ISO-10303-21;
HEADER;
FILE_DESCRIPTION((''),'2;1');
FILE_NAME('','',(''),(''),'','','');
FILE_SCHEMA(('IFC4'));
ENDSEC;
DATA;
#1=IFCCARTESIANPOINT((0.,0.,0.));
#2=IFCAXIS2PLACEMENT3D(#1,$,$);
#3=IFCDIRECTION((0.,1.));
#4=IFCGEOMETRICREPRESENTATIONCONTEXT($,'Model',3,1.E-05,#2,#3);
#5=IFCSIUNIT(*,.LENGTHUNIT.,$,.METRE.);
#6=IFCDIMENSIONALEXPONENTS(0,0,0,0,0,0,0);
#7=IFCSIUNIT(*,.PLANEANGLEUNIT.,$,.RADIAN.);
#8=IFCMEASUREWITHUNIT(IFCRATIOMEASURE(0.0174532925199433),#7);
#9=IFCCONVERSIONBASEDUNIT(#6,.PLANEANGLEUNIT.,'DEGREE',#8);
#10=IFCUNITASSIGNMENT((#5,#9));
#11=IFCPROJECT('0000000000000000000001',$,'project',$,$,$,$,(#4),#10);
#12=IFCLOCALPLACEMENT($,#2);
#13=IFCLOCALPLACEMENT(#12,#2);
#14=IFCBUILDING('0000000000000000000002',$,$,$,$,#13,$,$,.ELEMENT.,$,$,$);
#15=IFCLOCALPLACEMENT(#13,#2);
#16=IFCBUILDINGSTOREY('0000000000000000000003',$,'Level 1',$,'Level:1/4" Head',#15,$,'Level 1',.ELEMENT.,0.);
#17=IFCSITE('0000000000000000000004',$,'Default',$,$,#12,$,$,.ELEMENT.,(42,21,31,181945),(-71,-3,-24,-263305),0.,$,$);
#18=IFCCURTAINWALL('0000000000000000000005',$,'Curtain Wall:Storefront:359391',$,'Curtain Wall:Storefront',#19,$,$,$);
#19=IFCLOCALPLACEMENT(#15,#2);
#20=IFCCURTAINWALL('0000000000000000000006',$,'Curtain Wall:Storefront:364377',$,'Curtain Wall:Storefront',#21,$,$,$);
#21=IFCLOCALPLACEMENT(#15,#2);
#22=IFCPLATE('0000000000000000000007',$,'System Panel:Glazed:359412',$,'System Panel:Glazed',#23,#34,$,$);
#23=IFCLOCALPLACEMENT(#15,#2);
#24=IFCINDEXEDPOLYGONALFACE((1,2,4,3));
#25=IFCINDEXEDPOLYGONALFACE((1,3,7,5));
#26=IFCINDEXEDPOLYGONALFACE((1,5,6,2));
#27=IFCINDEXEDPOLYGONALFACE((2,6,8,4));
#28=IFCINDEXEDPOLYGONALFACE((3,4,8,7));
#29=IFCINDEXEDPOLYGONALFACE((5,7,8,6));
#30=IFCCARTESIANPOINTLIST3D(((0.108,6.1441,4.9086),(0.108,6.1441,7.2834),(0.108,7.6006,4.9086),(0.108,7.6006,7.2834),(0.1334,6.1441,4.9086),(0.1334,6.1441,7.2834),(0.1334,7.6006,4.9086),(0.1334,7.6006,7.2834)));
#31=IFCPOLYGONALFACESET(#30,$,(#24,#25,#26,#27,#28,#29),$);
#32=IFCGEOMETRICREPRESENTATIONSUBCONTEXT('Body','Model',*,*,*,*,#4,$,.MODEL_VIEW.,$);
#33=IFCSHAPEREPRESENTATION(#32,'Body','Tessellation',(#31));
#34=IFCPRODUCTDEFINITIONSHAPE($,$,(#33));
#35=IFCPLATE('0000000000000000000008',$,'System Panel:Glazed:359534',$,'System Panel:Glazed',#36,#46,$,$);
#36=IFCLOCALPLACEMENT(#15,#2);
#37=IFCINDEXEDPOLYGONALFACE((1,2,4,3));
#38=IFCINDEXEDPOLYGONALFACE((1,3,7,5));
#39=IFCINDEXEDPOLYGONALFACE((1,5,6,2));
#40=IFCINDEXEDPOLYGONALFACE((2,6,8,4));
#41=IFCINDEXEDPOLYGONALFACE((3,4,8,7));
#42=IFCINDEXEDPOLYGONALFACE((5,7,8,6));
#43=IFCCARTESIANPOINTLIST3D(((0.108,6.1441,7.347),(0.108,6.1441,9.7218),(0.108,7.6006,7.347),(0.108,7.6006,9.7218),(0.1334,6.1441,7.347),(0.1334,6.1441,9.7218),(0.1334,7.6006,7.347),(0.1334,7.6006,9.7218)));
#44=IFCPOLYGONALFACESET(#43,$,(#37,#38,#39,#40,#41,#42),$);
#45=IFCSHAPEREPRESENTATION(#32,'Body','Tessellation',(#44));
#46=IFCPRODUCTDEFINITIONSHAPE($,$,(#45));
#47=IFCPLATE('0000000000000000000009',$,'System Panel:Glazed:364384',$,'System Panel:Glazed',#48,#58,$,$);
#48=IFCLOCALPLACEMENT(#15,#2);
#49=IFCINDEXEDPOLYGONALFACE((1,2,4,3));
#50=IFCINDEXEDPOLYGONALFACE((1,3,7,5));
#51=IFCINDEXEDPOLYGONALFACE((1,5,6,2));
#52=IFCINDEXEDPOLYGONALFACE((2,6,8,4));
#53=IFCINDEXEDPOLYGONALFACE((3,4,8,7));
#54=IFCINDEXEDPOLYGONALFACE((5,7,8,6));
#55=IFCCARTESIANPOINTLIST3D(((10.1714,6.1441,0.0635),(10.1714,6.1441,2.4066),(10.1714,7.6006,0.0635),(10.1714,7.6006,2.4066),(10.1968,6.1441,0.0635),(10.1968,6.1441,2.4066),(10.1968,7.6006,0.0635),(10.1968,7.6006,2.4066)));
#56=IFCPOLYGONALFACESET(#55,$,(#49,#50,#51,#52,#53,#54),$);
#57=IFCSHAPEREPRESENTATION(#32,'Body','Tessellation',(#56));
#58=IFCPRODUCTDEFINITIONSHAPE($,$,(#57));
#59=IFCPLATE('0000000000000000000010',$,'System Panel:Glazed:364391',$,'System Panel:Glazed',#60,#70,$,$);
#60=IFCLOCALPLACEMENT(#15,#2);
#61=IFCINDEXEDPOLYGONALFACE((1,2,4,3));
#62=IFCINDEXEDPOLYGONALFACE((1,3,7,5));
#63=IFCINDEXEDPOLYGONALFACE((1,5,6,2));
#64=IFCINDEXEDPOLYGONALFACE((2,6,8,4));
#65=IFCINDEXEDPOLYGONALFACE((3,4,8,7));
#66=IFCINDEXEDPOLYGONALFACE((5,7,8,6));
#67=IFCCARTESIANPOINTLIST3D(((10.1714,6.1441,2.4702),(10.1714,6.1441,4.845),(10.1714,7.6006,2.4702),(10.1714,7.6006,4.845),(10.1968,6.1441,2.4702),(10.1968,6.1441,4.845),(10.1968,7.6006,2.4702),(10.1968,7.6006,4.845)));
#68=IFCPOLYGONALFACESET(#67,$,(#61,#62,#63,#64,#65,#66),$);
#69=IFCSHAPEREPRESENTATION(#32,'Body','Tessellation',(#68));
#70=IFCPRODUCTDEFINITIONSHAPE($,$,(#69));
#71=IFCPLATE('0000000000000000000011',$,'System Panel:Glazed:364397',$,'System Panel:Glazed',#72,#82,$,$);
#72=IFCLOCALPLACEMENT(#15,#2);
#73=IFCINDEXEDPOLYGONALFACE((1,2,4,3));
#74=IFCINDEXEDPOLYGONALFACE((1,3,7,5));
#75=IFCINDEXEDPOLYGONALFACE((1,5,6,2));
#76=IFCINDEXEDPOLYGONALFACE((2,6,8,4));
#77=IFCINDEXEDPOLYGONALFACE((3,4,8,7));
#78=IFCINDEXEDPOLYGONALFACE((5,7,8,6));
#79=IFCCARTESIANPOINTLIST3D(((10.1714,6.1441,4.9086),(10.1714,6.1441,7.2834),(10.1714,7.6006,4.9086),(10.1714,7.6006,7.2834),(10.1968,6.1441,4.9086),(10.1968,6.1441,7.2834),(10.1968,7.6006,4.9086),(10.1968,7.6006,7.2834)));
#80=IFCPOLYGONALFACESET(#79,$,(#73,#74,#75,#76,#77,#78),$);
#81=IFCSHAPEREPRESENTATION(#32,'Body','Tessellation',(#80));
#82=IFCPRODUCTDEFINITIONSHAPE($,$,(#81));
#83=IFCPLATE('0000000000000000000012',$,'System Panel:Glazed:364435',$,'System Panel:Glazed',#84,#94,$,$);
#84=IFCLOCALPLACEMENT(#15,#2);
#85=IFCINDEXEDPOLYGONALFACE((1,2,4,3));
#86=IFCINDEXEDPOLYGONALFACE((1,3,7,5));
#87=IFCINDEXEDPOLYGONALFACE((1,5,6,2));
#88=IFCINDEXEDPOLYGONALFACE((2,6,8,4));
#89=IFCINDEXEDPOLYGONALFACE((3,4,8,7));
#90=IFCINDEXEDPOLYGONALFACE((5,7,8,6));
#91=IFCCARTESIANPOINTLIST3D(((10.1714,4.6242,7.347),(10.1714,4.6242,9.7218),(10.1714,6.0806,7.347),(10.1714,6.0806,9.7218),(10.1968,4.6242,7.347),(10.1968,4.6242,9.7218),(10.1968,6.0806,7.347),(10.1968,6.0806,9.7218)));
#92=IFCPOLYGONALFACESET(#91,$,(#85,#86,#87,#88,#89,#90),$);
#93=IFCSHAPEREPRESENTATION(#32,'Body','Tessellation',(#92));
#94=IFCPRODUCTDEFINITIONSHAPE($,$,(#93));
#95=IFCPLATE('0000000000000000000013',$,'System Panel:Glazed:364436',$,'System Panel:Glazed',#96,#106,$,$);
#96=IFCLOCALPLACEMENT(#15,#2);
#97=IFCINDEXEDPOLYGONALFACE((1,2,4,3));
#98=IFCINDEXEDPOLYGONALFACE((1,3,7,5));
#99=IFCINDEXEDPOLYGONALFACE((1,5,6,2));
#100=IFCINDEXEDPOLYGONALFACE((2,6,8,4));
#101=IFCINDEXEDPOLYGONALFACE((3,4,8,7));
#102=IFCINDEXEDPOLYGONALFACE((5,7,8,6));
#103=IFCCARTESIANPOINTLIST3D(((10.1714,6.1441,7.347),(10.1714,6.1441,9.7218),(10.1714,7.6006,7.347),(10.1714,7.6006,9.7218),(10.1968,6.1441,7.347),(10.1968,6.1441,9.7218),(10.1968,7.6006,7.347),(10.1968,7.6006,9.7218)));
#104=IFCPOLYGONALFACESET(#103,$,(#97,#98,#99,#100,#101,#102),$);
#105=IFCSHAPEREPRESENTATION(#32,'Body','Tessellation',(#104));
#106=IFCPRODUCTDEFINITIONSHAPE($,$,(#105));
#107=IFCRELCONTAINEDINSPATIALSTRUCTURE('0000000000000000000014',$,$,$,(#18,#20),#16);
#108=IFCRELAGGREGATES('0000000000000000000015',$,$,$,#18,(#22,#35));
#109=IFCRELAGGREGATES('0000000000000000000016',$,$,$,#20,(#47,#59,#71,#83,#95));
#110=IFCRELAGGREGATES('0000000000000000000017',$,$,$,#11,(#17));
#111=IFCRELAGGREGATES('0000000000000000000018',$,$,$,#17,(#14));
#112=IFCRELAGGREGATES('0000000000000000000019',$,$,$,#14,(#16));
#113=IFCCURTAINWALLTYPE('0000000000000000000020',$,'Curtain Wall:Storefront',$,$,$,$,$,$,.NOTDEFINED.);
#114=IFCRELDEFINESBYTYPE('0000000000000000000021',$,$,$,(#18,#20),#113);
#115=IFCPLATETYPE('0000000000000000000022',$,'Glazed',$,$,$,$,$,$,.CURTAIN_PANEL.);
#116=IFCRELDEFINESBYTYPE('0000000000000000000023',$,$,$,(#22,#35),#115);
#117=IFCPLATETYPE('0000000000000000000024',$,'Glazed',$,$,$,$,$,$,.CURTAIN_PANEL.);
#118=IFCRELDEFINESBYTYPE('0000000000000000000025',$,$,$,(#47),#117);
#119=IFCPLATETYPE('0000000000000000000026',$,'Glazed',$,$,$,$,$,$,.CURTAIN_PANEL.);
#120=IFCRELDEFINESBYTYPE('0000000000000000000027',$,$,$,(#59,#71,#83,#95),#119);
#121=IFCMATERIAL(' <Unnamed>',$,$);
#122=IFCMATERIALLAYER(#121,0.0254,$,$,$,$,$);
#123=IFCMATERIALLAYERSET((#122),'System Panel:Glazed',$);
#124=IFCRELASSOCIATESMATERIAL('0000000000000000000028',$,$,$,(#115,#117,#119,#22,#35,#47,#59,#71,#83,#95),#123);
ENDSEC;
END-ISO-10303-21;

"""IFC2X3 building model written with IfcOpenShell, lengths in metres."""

from ifc_helpers import new_model, entity, si_unit, converted_unit, direction, frame, frame_2d, origin, origin_2d_with_axis, place, context, subcontext, project, spatial, rectangle, extrude, source, transform, mapped, material, layer, layer_set, layer_usage, type_object, type_shapes, element, aggregate, save


model = new_model("IFC2X3")

# Units and contexts
model_context = context("Model", 3, precision=1e-05, world=origin(), true_north=direction((0.0, 1.0)))
body_context = subcontext(model_context, "Body", "Model", "MODEL_VIEW")
ifc_project = project(units=[si_unit("LENGTHUNIT", "METRE"), converted_unit("PLANEANGLEUNIT", "DEGREE", entity("IfcRatioMeasure", 0.0174532925199433), si_unit("PLANEANGLEUNIT", "RADIAN"), dimensions=[0, 0, 0, 0, 0, 0, 0])], contexts=[model_context])

# Site, building, storey
site_placement = place(None, origin())
site = spatial("IfcSite", under=ifc_project, at=site_placement, Name="Default", CompositionType="ELEMENT", RefLatitude=(42, 21, 31, 181945), RefLongitude=(-71, -3, -24, -263305), RefElevation=0.0)
building_placement = place(site_placement, origin())
building = spatial("IfcBuilding", under=site, at=building_placement, CompositionType="ELEMENT")
storey_placement = place(building_placement, origin())
storey = spatial("IfcBuildingStorey", under=building, at=storey_placement, Name="Level 1", ObjectType="Level:1/4\" Head", LongName="Level 1", CompositionType="ELEMENT", Elevation=0.0)

# Curtain walls
curtain_wall_type = type_object("IfcCurtainWallType", Name="Curtain Wall:Storefront", PredefinedType="NOTDEFINED")
curtain_wall_1_placement = place(storey_placement, origin())
curtain_wall_1 = element("IfcCurtainWall", 1, at=curtain_wall_1_placement, inside=storey, type_object=curtain_wall_type, Name="Curtain Wall:Storefront:359391", ObjectType="Curtain Wall:Storefront")
curtain_wall_2_placement = place(storey_placement, origin())
curtain_wall_2 = element("IfcCurtainWall", 2, at=curtain_wall_2_placement, inside=storey, type_object=curtain_wall_type, Name="Curtain Wall:Storefront:364377", ObjectType="Curtain Wall:Storefront")

# Plates
ifc_material_1 = material(Name=" <Unnamed>")
ifc_layer = layer(ifc_material_1, 0.0254)
ifc_layer_set = layer_set([ifc_layer], Name="System Panel:Glazed")
plate_type_1 = type_object("IfcPlateType", Name="Glazed", PredefinedType="CURTAIN_PANEL", material=ifc_layer_set)
shared_shape_1 = source(origin(), body_context, "Body", "SweptSolid", [
    extrude(rectangle(XDim=0.0254, YDim=1.4565, at=frame_2d((0.0, 0.0), x_axis=(1.0, 0.0))), frame((0.7282, 0.0127, 0.0), z_axis=(0.0, 0.0, 1.0), x_axis=(0.0, 1.0, 0.0)), (0.0, 0.0, 1.0), 2.3749),
])
type_shapes(plate_type_1, [shared_shape_1])
ifc_layer_usage_1 = layer_usage(ifc_layer_set, "AXIS3", "POSITIVE", 0.1042)
plate_1_placement = place(curtain_wall_1_placement, frame((0.1334, 6.1441, 4.9085), z_axis=(0.0, 0.0, 1.0), x_axis=(0.0, 1.0, 0.0)))
plate_1 = element("IfcPlate", 3, at=plate_1_placement, type_object=plate_type_1, material=ifc_layer_usage_1, Name="System Panel:Glazed:359412", ObjectType="System Panel:Glazed", context=body_context, shape_type="MappedRepresentation", body=[
    mapped(shared_shape_1, transform((0.0, 0.0, 0.0), scale=1.0)),
])
ifc_layer_usage_2 = layer_usage(ifc_layer_set, "AXIS3", "POSITIVE", 0.1042)
plate_2_placement = place(curtain_wall_1_placement, frame((0.1334, 6.1441, 7.3469), z_axis=(0.0, 0.0, 1.0), x_axis=(0.0, 1.0, 0.0)))
plate_2 = element("IfcPlate", 4, at=plate_2_placement, type_object=plate_type_1, material=ifc_layer_usage_2, Name="System Panel:Glazed:359534", ObjectType="System Panel:Glazed", context=body_context, shape_type="MappedRepresentation", body=[
    mapped(shared_shape_1, transform((0.0, 0.0, 0.0), scale=1.0)),
])
aggregate(curtain_wall_1, [plate_1, plate_2])
ifc_layer_usage_3 = layer_usage(ifc_layer_set, "AXIS3", "POSITIVE", 0.1042)
plate_type_2 = type_object("IfcPlateType", Name="Glazed", PredefinedType="CURTAIN_PANEL", material=ifc_layer_set)
shared_shape_2 = source(origin(), body_context, "Body", "SweptSolid", [
    extrude(rectangle(XDim=0.0254, YDim=1.4565, at=origin_2d_with_axis()), frame((0.7282, 0.0127, 0.0), z_axis=(0.0, 0.0, 1.0), x_axis=(0.0, 1.0, 0.0)), (0.0, 0.0, 1.0), 2.3432),
])
type_shapes(plate_type_2, [shared_shape_2])
plate_3_placement = place(curtain_wall_2_placement, frame((10.1968, 6.1441, 0.0635), z_axis=(0.0, 0.0, 1.0), x_axis=(0.0, 1.0, 0.0)))
plate_3 = element("IfcPlate", 5, at=plate_3_placement, type_object=plate_type_2, material=ifc_layer_usage_3, Name="System Panel:Glazed:364384", ObjectType="System Panel:Glazed", context=body_context, shape_type="MappedRepresentation", body=[
    mapped(shared_shape_2, transform((0.0, 0.0, 0.0), scale=1.0)),
])
ifc_layer_usage_4 = layer_usage(ifc_layer_set, "AXIS3", "POSITIVE", 0.1042)
plate_type_3 = type_object("IfcPlateType", Name="Glazed", PredefinedType="CURTAIN_PANEL", material=ifc_layer_set)
shared_shape_3 = source(origin(), body_context, "Body", "SweptSolid", [
    extrude(rectangle(XDim=0.0254, YDim=1.4565, at=origin_2d_with_axis()), frame((0.7282, 0.0127, 0.0), z_axis=(0.0, 0.0, 1.0), x_axis=(0.0, 1.0, 0.0)), (0.0, 0.0, 1.0), 2.3749),
])
type_shapes(plate_type_3, [shared_shape_3])
plate_4_placement = place(curtain_wall_2_placement, frame((10.1968, 6.1441, 2.4701), z_axis=(0.0, 0.0, 1.0), x_axis=(0.0, 1.0, 0.0)))
plate_4 = element("IfcPlate", 6, at=plate_4_placement, type_object=plate_type_3, material=ifc_layer_usage_4, Name="System Panel:Glazed:364391", ObjectType="System Panel:Glazed", context=body_context, shape_type="MappedRepresentation", body=[
    mapped(shared_shape_3, transform((0.0, 0.0, 0.0), scale=1.0)),
])
ifc_layer_usage_5 = layer_usage(ifc_layer_set, "AXIS3", "POSITIVE", 0.1042)
plate_5_placement = place(curtain_wall_2_placement, frame((10.1968, 6.1441, 4.9085), z_axis=(0.0, 0.0, 1.0), x_axis=(0.0, 1.0, 0.0)))
plate_5 = element("IfcPlate", 7, at=plate_5_placement, type_object=plate_type_3, material=ifc_layer_usage_5, Name="System Panel:Glazed:364397", ObjectType="System Panel:Glazed", context=body_context, shape_type="MappedRepresentation", body=[
    mapped(shared_shape_3, transform((0.0, 0.0, 0.0), scale=1.0)),
])
ifc_layer_usage_6 = layer_usage(ifc_layer_set, "AXIS3", "POSITIVE", 0.1042)
plate_6_placement = place(curtain_wall_2_placement, frame((10.1968, 4.6242, 7.3469), z_axis=(0.0, 0.0, 1.0), x_axis=(0.0, 1.0, 0.0)))
plate_6 = element("IfcPlate", 8, at=plate_6_placement, type_object=plate_type_3, material=ifc_layer_usage_6, Name="System Panel:Glazed:364435", ObjectType="System Panel:Glazed", context=body_context, shape_type="MappedRepresentation", body=[
    mapped(shared_shape_3, transform((0.0, 0.0, 0.0), scale=1.0)),
])
ifc_layer_usage_7 = layer_usage(ifc_layer_set, "AXIS3", "POSITIVE", 0.1042)
plate_7_placement = place(curtain_wall_2_placement, frame((10.1968, 6.1441, 7.3469), z_axis=(0.0, 0.0, 1.0), x_axis=(0.0, 1.0, 0.0)))
plate_7 = element("IfcPlate", 9, at=plate_7_placement, type_object=plate_type_3, material=ifc_layer_usage_7, Name="System Panel:Glazed:364436", ObjectType="System Panel:Glazed", context=body_context, shape_type="MappedRepresentation", body=[
    mapped(shared_shape_3, transform((0.0, 0.0, 0.0), scale=1.0)),
])
aggregate(curtain_wall_2, [plate_3, plate_4, plate_5, plate_6, plate_7])

save(model, "model.ifc")
